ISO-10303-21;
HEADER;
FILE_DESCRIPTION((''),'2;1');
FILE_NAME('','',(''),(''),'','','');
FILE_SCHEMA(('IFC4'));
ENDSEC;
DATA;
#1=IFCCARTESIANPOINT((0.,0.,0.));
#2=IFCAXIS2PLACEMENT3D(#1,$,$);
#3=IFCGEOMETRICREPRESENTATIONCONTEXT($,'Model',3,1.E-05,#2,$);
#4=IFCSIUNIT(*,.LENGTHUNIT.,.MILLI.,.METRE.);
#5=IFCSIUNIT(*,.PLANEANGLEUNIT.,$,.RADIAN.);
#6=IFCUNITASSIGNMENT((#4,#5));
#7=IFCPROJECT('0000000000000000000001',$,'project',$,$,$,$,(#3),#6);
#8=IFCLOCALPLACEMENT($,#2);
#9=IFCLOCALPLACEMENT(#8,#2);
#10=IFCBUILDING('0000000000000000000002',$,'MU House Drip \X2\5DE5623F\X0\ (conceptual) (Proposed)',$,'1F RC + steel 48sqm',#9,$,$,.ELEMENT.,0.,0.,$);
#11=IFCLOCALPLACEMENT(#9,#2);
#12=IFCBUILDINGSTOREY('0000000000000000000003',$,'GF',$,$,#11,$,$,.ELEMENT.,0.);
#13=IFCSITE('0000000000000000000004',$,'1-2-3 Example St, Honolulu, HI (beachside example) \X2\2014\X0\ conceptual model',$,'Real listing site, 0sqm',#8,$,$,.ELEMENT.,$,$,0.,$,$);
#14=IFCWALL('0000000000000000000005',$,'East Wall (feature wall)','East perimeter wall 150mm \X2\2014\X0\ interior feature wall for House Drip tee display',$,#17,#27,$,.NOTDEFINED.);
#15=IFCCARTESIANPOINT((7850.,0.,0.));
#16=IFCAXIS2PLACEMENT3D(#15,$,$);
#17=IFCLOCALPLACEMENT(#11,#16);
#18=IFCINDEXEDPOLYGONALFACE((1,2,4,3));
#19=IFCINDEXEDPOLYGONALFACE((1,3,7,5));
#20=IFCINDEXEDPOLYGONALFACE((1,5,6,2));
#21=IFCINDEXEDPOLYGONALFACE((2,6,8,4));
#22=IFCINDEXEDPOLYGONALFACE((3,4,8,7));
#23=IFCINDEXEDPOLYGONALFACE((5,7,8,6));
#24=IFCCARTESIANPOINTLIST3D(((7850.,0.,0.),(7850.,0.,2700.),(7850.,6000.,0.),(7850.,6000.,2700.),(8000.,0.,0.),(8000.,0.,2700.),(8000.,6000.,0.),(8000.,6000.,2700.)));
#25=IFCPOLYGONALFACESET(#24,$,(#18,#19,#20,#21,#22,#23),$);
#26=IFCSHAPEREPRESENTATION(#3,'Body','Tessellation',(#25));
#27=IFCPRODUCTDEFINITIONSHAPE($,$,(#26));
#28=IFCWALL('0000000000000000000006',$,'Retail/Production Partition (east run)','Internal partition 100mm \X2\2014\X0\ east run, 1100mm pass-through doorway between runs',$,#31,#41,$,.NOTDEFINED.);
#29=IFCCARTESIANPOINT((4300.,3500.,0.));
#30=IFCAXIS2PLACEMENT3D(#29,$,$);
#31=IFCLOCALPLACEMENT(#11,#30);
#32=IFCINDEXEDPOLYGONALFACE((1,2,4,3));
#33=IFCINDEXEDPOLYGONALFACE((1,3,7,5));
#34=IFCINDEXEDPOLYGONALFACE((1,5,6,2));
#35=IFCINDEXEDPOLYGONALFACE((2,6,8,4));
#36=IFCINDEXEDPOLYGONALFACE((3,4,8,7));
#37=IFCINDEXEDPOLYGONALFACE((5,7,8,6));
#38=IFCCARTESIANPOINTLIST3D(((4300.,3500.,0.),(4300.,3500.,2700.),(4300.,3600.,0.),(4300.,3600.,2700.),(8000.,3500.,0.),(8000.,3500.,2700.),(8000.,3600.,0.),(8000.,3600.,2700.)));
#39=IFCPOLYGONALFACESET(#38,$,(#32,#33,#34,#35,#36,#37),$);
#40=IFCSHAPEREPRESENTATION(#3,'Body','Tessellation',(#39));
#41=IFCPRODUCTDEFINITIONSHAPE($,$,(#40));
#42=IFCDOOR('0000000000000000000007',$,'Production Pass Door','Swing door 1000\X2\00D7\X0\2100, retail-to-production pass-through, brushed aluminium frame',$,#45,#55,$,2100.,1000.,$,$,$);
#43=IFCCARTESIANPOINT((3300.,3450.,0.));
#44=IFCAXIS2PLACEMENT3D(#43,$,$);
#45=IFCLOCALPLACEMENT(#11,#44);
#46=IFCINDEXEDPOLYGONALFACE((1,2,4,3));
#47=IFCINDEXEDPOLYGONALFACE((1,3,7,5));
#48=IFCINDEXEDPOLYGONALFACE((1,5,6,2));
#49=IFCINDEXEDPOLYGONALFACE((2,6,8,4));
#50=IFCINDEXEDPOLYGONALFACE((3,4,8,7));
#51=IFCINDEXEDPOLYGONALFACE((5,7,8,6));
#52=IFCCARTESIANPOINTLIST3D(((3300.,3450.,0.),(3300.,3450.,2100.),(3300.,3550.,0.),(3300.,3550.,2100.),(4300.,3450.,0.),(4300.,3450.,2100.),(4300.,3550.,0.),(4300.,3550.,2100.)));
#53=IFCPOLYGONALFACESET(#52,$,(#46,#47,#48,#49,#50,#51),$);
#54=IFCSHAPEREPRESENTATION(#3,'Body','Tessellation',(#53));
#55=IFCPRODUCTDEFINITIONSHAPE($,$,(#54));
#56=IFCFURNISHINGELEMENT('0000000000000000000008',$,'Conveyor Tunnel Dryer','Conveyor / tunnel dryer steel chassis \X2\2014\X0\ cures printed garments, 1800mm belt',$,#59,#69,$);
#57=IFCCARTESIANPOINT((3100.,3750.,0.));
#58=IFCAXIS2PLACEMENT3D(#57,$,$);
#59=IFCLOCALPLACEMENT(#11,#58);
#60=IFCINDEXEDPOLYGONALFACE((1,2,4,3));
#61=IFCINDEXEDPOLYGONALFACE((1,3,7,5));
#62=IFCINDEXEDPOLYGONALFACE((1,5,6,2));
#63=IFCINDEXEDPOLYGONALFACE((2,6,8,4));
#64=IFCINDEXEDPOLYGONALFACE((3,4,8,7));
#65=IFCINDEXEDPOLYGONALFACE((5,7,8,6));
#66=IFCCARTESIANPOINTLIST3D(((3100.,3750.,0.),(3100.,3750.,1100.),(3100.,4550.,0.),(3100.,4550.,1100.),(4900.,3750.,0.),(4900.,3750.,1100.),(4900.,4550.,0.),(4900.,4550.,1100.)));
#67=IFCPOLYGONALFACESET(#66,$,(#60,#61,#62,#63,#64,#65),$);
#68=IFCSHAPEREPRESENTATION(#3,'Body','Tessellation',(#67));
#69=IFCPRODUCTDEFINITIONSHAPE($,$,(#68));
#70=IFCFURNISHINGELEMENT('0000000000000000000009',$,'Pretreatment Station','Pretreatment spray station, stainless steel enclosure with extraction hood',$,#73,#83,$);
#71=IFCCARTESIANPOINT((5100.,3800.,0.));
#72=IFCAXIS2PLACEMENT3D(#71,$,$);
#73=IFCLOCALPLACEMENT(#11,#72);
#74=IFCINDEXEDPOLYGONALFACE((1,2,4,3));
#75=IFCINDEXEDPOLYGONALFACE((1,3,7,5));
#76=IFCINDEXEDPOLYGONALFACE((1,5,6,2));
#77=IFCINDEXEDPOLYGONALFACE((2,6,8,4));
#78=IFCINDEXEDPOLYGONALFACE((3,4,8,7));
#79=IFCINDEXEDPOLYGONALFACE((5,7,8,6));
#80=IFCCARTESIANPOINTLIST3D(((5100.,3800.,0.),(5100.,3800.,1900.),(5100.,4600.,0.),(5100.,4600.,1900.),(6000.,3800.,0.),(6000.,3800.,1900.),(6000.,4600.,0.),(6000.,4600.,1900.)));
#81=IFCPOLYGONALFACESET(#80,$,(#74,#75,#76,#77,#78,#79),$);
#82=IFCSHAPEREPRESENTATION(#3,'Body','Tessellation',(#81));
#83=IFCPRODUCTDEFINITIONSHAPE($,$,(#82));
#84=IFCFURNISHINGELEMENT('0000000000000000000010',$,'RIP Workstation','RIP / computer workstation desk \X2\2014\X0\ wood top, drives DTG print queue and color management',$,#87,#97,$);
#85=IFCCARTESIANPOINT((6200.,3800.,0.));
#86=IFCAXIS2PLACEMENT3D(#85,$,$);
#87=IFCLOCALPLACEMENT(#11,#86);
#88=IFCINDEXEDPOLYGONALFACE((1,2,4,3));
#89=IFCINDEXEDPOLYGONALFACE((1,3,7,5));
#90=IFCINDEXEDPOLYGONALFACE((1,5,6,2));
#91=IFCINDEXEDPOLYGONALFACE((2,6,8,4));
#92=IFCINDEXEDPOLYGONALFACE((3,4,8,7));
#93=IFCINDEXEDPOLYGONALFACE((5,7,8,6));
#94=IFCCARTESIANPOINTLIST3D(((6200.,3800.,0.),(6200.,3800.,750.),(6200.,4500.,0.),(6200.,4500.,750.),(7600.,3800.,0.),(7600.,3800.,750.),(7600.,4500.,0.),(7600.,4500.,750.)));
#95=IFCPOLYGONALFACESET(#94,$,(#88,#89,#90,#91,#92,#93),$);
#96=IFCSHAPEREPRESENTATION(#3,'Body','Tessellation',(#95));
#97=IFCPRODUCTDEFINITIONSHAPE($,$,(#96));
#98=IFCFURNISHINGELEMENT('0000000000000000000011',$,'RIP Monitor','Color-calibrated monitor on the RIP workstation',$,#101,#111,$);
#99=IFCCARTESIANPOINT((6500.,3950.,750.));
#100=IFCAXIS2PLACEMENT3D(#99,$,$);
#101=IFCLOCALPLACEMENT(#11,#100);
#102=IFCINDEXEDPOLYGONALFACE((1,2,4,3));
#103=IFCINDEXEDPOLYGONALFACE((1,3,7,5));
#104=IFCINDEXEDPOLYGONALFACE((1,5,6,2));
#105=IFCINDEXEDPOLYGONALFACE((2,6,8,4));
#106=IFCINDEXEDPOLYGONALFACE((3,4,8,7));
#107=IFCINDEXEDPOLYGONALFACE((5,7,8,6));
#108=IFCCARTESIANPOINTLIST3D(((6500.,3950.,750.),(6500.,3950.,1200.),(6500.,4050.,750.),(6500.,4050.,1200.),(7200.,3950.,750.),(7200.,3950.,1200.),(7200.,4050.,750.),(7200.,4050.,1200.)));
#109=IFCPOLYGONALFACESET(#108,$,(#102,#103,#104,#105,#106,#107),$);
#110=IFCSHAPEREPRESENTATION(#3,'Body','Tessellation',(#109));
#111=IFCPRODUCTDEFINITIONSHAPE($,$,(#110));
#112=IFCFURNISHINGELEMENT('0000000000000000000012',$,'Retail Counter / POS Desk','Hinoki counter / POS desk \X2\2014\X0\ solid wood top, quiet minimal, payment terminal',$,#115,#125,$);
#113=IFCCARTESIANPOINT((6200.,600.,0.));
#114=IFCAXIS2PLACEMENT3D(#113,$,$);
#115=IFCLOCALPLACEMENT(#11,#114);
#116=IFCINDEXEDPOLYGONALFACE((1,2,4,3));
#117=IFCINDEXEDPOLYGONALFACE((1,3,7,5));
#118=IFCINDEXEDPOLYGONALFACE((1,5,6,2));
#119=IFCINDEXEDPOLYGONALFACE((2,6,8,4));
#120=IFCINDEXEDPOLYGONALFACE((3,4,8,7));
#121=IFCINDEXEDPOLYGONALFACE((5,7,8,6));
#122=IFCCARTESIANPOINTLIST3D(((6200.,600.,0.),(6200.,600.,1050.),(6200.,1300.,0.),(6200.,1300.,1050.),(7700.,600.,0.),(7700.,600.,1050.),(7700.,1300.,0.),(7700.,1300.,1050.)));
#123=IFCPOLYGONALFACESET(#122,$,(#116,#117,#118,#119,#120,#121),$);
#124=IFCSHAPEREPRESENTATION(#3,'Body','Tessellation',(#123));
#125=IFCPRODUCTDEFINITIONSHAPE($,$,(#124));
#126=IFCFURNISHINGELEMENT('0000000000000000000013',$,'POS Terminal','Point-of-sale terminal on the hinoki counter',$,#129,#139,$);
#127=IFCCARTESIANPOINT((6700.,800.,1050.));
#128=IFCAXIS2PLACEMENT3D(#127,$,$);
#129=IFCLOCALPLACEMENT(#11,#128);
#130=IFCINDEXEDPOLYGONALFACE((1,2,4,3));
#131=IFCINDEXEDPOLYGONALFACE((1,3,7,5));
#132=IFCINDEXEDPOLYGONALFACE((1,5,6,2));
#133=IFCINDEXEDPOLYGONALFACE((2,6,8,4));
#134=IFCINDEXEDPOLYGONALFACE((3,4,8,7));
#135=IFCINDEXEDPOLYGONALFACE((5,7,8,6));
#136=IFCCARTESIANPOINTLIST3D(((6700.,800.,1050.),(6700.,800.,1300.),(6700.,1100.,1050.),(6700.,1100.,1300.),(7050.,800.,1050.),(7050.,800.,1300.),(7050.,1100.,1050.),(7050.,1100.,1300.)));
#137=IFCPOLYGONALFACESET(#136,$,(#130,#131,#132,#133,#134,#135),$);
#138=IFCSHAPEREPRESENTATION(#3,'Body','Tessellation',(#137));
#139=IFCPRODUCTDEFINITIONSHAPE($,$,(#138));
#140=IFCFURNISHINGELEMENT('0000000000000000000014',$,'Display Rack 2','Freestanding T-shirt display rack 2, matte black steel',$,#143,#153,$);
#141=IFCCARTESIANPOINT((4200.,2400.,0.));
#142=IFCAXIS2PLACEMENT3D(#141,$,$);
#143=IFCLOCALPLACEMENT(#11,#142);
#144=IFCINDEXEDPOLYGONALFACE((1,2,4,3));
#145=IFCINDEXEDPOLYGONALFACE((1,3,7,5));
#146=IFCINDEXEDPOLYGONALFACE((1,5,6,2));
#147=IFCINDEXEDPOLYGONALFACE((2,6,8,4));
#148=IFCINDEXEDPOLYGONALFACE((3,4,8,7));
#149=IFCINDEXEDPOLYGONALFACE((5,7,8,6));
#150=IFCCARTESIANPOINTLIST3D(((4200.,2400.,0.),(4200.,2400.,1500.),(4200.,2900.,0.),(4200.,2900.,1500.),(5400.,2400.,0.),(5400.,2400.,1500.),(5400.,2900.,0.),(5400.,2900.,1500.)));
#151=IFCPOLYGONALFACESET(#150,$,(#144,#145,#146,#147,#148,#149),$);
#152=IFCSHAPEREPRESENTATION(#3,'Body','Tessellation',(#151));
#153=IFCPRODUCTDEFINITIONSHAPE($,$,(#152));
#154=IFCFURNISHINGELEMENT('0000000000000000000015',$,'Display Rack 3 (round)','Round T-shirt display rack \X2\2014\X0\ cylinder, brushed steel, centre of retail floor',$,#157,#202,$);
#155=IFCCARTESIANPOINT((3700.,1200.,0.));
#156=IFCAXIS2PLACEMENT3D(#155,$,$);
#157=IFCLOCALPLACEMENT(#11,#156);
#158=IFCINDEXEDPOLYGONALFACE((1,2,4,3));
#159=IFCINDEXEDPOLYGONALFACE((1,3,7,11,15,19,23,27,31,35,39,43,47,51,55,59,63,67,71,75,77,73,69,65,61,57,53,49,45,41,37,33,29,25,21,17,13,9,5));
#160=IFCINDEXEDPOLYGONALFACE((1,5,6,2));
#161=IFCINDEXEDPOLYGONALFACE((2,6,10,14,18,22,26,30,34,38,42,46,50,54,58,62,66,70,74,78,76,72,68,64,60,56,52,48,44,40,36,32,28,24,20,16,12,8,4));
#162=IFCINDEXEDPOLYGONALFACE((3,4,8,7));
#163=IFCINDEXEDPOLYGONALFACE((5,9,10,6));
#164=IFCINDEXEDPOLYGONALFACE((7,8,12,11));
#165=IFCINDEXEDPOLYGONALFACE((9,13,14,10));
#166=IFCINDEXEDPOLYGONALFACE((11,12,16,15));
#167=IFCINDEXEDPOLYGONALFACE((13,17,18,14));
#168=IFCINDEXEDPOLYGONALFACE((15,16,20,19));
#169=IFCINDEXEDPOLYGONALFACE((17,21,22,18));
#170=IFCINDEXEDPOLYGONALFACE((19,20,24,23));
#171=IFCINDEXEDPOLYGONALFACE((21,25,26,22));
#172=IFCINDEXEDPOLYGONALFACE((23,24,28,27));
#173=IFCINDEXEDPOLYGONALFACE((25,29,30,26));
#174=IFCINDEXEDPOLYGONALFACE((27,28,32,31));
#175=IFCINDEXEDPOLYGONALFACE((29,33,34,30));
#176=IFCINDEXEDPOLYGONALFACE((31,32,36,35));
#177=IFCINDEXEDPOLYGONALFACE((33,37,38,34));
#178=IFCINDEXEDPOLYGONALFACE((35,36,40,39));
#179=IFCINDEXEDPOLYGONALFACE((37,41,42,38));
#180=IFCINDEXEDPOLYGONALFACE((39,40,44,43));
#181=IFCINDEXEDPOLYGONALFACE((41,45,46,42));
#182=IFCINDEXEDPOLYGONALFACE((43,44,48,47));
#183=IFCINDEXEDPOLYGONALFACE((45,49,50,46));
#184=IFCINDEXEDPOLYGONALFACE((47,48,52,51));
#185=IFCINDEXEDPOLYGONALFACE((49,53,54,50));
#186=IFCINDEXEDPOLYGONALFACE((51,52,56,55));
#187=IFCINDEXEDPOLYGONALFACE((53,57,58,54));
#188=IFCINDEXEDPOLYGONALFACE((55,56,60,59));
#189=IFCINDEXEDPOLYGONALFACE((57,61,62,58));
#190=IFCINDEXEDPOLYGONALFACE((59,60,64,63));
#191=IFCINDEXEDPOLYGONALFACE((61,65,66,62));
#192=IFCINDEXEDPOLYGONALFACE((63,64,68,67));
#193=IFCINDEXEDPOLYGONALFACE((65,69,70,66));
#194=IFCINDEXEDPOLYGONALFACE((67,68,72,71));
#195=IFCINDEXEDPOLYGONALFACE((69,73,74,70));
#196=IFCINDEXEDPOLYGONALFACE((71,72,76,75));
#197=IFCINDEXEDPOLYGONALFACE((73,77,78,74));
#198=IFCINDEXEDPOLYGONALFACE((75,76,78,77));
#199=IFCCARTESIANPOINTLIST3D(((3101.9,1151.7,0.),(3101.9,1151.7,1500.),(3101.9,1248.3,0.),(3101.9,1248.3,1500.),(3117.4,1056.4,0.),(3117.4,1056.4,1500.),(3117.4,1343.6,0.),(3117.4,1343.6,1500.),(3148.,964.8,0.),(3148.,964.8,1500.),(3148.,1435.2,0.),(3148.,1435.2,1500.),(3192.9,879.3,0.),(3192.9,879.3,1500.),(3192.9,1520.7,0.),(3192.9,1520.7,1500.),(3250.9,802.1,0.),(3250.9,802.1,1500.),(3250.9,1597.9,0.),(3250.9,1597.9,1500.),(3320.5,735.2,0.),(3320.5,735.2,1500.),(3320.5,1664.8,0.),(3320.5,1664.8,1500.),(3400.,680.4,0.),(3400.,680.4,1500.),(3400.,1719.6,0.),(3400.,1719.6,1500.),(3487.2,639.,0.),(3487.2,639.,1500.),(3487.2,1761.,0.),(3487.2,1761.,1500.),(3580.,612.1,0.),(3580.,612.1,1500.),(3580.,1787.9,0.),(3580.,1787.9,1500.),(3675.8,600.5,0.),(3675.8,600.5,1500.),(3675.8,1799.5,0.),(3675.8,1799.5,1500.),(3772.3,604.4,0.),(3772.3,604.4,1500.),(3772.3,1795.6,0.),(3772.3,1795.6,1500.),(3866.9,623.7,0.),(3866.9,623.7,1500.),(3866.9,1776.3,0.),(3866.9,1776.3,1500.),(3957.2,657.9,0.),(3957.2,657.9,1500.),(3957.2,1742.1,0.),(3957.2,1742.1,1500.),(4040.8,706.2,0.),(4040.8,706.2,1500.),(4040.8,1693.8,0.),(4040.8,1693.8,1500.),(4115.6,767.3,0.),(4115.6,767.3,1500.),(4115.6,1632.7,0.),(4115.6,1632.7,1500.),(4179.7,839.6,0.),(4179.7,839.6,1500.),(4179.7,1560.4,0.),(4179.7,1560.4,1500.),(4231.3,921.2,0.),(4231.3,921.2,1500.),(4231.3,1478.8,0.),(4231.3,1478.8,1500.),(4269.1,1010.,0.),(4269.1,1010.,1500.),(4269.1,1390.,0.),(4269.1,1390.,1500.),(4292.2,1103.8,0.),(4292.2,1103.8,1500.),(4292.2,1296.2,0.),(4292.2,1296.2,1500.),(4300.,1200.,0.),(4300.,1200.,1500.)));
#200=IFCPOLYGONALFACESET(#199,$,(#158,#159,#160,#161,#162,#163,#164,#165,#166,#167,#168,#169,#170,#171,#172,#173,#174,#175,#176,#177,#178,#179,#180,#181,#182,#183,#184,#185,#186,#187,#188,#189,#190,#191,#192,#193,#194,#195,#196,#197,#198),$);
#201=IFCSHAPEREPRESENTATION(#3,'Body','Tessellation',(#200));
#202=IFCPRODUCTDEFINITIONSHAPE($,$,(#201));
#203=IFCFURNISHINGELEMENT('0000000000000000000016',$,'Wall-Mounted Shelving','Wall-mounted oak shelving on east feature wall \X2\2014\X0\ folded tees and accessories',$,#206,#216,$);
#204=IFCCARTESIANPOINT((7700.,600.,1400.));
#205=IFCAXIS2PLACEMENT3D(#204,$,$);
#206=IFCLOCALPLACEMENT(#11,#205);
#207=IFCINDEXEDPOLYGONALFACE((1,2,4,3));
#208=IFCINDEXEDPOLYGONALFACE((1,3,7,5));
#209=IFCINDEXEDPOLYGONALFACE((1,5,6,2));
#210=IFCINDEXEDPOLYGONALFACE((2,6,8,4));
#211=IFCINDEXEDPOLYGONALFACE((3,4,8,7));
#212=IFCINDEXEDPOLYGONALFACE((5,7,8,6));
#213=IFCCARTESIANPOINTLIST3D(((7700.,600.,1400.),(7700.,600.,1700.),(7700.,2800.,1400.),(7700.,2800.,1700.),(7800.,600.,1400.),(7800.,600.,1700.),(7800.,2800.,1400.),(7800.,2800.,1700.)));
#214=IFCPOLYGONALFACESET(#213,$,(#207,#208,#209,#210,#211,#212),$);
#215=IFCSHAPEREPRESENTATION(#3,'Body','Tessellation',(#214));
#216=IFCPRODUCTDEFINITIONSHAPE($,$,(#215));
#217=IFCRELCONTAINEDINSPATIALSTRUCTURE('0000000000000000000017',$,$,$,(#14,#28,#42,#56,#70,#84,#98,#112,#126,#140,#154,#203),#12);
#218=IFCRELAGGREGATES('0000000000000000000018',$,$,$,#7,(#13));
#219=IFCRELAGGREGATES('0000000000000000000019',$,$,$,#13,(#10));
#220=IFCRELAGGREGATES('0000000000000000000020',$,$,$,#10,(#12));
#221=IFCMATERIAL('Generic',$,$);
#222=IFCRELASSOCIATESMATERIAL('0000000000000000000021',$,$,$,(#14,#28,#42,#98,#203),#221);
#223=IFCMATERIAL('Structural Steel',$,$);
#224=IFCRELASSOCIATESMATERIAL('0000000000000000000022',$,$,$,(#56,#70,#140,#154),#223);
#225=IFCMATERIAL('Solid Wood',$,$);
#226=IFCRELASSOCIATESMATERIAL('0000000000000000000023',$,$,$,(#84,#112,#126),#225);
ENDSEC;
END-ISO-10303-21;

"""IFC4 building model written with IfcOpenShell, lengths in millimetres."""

from ifc_helpers import new_model, si_unit, frame, frame_2d, origin, origin_2d, place, context, project, spatial, rectangle, circle, extrude, material, element, save


model = new_model("IFC4")

# Units and contexts
model_context = context("Model", 3, precision=1e-05, world=origin())
ifc_project = project(units=[si_unit("LENGTHUNIT", "METRE", prefix="MILLI"), si_unit("PLANEANGLEUNIT", "RADIAN")], contexts=[model_context])

# Site, building, storey
site_placement = place(None, origin())
site = spatial("IfcSite", under=ifc_project, at=site_placement, Name="1-2-3 Example St, Honolulu, HI (beachside example) — conceptual model", ObjectType="Real listing site, 0sqm", CompositionType="ELEMENT", RefElevation=0.0)
building_placement = place(site_placement, origin())
building = spatial("IfcBuilding", under=site, at=building_placement, Name="MU House Drip 工房 (conceptual) (Proposed)", ObjectType="1F RC + steel 48sqm", CompositionType="ELEMENT", ElevationOfRefHeight=0.0, ElevationOfTerrain=0.0)
storey_placement = place(building_placement, origin())
storey = spatial("IfcBuildingStorey", under=building, at=storey_placement, Name="GF", CompositionType="ELEMENT", Elevation=0.0)

# Walls
ifc_material_1 = material(Name="Generic")
wall_1_placement = place(storey_placement, frame((7850.0, 0.0, 0.0)))
element("IfcWall", 1, at=wall_1_placement, inside=storey, material=ifc_material_1, Name="East Wall (feature wall)", Description="East perimeter wall 150mm — interior feature wall for House Drip tee display", PredefinedType="NOTDEFINED", context=model_context, shape_type="SweptSolid", body=[
    extrude(rectangle(XDim=150.0, YDim=6000.0, at=frame_2d((75.0, 3000.0))), frame((7850.0, 0.0, 0.0)), (0.0, 0.0, 1.0), 2700.0),
])
wall_2_placement = place(storey_placement, frame((4300.0, 3500.0, 0.0)))
element("IfcWall", 2, at=wall_2_placement, inside=storey, material=ifc_material_1, Name="Retail/Production Partition (east run)", Description="Internal partition 100mm — east run, 1100mm pass-through doorway between runs", PredefinedType="NOTDEFINED", context=model_context, shape_type="SweptSolid", body=[
    extrude(rectangle(XDim=3700.0, YDim=100.0, at=frame_2d((1850.0, 50.0))), frame((4300.0, 3500.0, 0.0)), (0.0, 0.0, 1.0), 2700.0),
])

# Door
door_placement = place(storey_placement, frame((3300.0, 3450.0, 0.0)))
element("IfcDoor", 3, at=door_placement, inside=storey, material=ifc_material_1, Name="Production Pass Door", Description="Swing door 1000×2100, retail-to-production pass-through, brushed aluminium frame", OverallHeight=2100.0, OverallWidth=1000.0, context=model_context, shape_type="SweptSolid", body=[
    extrude(rectangle(XDim=1000.0, YDim=100.0, at=frame_2d((500.0, 50.0))), frame((3300.0, 3450.0, 0.0)), (0.0, 0.0, 1.0), 2100.0),
])

# Furnishing elements
ifc_material_2 = material(Name="Structural Steel")
furnishing_1_placement = place(storey_placement, frame((3100.0, 3750.0, 0.0)))
element("IfcFurnishingElement", 4, at=furnishing_1_placement, inside=storey, material=ifc_material_2, Name="Conveyor Tunnel Dryer", Description="Conveyor / tunnel dryer steel chassis — cures printed garments, 1800mm belt", context=model_context, shape_type="SweptSolid", body=[
    extrude(rectangle(XDim=1800.0, YDim=800.0, at=frame_2d((900.0, 400.0))), frame((3100.0, 3750.0, 0.0)), (0.0, 0.0, 1.0), 1100.0),
])
furnishing_2_placement = place(storey_placement, frame((5100.0, 3800.0, 0.0)))
element("IfcFurnishingElement", 5, at=furnishing_2_placement, inside=storey, material=ifc_material_2, Name="Pretreatment Station", Description="Pretreatment spray station, stainless steel enclosure with extraction hood", context=model_context, shape_type="SweptSolid", body=[
    extrude(rectangle(XDim=900.0, YDim=800.0, at=frame_2d((450.0, 400.0))), frame((5100.0, 3800.0, 0.0)), (0.0, 0.0, 1.0), 1900.0),
])
ifc_material_3 = material(Name="Solid Wood")
furnishing_3_placement = place(storey_placement, frame((6200.0, 3800.0, 0.0)))
element("IfcFurnishingElement", 6, at=furnishing_3_placement, inside=storey, material=ifc_material_3, Name="RIP Workstation", Description="RIP / computer workstation desk — wood top, drives DTG print queue and color management", context=model_context, shape_type="SweptSolid", body=[
    extrude(rectangle(XDim=1400.0, YDim=700.0, at=frame_2d((700.0, 350.0))), frame((6200.0, 3800.0, 0.0)), (0.0, 0.0, 1.0), 750.0),
])
furnishing_4_placement = place(storey_placement, frame((6500.0, 3950.0, 750.0)))
element("IfcFurnishingElement", 7, at=furnishing_4_placement, inside=storey, material=ifc_material_1, Name="RIP Monitor", Description="Color-calibrated monitor on the RIP workstation", context=model_context, shape_type="SweptSolid", body=[
    extrude(rectangle(XDim=700.0, YDim=100.0, at=frame_2d((350.0, 50.0))), frame((6500.0, 3950.0, 750.0)), (0.0, 0.0, 1.0), 450.0),
])
furnishing_5_placement = place(storey_placement, frame((6200.0, 600.0, 0.0)))
element("IfcFurnishingElement", 8, at=furnishing_5_placement, inside=storey, material=ifc_material_3, Name="Retail Counter / POS Desk", Description="Hinoki counter / POS desk — solid wood top, quiet minimal, payment terminal", context=model_context, shape_type="SweptSolid", body=[
    extrude(rectangle(XDim=1500.0, YDim=700.0, at=frame_2d((750.0, 350.0))), frame((6200.0, 600.0, 0.0)), (0.0, 0.0, 1.0), 1050.0),
])
furnishing_6_placement = place(storey_placement, frame((6700.0, 800.0, 1050.0)))
element("IfcFurnishingElement", 9, at=furnishing_6_placement, inside=storey, material=ifc_material_3, Name="POS Terminal", Description="Point-of-sale terminal on the hinoki counter", context=model_context, shape_type="SweptSolid", body=[
    extrude(rectangle(XDim=350.0, YDim=300.0, at=frame_2d((175.0, 150.0))), frame((6700.0, 800.0, 1050.0)), (0.0, 0.0, 1.0), 250.0),
])
furnishing_7_placement = place(storey_placement, frame((4200.0, 2400.0, 0.0)))
element("IfcFurnishingElement", 10, at=furnishing_7_placement, inside=storey, material=ifc_material_2, Name="Display Rack 2", Description="Freestanding T-shirt display rack 2, matte black steel", context=model_context, shape_type="SweptSolid", body=[
    extrude(rectangle(XDim=1200.0, YDim=500.0, at=frame_2d((600.0, 250.0))), frame((4200.0, 2400.0, 0.0)), (0.0, 0.0, 1.0), 1500.0),
])
furnishing_8_placement = place(storey_placement, frame((3700.0, 1200.0, 0.0)))
element("IfcFurnishingElement", 11, at=furnishing_8_placement, inside=storey, material=ifc_material_2, Name="Display Rack 3 (round)", Description="Round T-shirt display rack — cylinder, brushed steel, centre of retail floor", context=model_context, shape_type="SweptSolid", body=[
    extrude(circle(Radius=600.0, at=origin_2d()), frame((3700.0, 1200.0, 0.0)), (0.0, 0.0, 1.0), 1500.0),
])
furnishing_9_placement = place(storey_placement, frame((7700.0, 600.0, 1400.0)))
element("IfcFurnishingElement", 12, at=furnishing_9_placement, inside=storey, material=ifc_material_1, Name="Wall-Mounted Shelving", Description="Wall-mounted oak shelving on east feature wall — folded tees and accessories", context=model_context, shape_type="SweptSolid", body=[
    extrude(rectangle(XDim=100.0, YDim=2200.0, at=frame_2d((50.0, 1100.0))), frame((7700.0, 600.0, 1400.0)), (0.0, 0.0, 1.0), 300.0),
])

save(model, "model.ifc")
